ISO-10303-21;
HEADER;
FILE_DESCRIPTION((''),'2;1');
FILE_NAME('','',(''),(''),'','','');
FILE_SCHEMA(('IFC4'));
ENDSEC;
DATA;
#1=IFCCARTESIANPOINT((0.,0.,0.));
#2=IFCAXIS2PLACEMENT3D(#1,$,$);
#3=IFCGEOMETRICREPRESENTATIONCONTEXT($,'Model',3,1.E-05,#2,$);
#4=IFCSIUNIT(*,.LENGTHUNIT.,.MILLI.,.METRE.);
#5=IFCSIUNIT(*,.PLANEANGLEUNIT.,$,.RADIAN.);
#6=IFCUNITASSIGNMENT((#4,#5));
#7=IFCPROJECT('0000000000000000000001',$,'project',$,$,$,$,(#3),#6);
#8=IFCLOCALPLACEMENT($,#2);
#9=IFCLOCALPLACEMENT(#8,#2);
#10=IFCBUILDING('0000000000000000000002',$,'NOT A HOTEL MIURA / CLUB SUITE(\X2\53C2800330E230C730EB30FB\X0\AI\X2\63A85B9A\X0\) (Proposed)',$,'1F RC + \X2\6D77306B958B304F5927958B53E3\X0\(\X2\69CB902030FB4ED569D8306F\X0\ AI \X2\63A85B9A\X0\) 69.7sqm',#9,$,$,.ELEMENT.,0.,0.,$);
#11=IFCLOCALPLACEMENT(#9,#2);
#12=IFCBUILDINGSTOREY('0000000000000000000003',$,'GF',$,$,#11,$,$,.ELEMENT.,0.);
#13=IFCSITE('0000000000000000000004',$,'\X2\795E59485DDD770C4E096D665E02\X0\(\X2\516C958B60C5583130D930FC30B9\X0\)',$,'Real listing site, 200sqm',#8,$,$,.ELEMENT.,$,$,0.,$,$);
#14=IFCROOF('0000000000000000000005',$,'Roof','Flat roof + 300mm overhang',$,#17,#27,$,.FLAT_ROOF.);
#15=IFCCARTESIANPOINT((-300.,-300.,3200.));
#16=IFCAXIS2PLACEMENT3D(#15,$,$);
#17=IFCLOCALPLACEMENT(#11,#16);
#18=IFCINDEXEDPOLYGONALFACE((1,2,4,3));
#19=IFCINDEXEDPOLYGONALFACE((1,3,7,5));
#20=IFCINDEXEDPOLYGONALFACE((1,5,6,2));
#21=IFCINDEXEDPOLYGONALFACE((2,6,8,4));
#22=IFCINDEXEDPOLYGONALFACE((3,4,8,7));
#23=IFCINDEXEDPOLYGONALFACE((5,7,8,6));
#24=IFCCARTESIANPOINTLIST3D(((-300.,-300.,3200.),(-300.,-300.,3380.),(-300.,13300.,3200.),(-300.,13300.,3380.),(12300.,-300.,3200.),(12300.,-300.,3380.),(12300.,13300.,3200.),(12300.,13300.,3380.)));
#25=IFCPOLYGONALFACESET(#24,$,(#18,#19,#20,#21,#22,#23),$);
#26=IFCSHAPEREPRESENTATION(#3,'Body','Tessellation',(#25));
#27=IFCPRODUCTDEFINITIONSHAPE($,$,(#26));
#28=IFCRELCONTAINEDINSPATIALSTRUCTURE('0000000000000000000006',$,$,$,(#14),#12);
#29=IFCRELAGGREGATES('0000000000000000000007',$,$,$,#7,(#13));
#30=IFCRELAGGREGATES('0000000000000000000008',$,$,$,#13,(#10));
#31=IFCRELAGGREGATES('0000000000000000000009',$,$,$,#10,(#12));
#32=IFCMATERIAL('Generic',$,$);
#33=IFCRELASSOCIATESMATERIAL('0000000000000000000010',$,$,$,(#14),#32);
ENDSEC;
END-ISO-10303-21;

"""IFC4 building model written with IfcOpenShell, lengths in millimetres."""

from ifc_helpers import new_model, si_unit, frame, frame_2d, origin, place, context, project, spatial, rectangle, extrude, material, element, save


model = new_model("IFC4")

# Units and contexts
model_context = context("Model", 3, precision=1e-05, world=origin())
ifc_project = project(units=[si_unit("LENGTHUNIT", "METRE", prefix="MILLI"), si_unit("PLANEANGLEUNIT", "RADIAN")], contexts=[model_context])

# Site, building, storey
site_placement = place(None, origin())
site = spatial("IfcSite", under=ifc_project, at=site_placement, Name="神奈川県三浦市(公開情報ベース)", ObjectType="Real listing site, 200sqm", CompositionType="ELEMENT", RefElevation=0.0)
building_placement = place(site_placement, origin())
building = spatial("IfcBuilding", under=site, at=building_placement, Name="NOT A HOTEL MIURA / CLUB SUITE(参考モデル・AI推定) (Proposed)", ObjectType="1F RC + 海に開く大開口(構造・仕様は AI 推定) 69.7sqm", CompositionType="ELEMENT", ElevationOfRefHeight=0.0, ElevationOfTerrain=0.0)
storey_placement = place(building_placement, origin())
storey = spatial("IfcBuildingStorey", under=building, at=storey_placement, Name="GF", CompositionType="ELEMENT", Elevation=0.0)

# Shared definitions
ifc_material_1 = material(Name="Generic")

# Roof
roof_placement = place(storey_placement, frame((-300.0, -300.0, 3200.0)))
element("IfcRoof", 1, at=roof_placement, inside=storey, material=ifc_material_1, Name="Roof", Description="Flat roof + 300mm overhang", PredefinedType="FLAT_ROOF", context=model_context, shape_type="SweptSolid", body=[
    extrude(rectangle(XDim=12600.0, YDim=13600.0, at=frame_2d((6300.0, 6800.0))), frame((-300.0, -300.0, 3200.0)), (0.0, 0.0, 1.0), 180.0),
])

save(model, "model.ifc")
